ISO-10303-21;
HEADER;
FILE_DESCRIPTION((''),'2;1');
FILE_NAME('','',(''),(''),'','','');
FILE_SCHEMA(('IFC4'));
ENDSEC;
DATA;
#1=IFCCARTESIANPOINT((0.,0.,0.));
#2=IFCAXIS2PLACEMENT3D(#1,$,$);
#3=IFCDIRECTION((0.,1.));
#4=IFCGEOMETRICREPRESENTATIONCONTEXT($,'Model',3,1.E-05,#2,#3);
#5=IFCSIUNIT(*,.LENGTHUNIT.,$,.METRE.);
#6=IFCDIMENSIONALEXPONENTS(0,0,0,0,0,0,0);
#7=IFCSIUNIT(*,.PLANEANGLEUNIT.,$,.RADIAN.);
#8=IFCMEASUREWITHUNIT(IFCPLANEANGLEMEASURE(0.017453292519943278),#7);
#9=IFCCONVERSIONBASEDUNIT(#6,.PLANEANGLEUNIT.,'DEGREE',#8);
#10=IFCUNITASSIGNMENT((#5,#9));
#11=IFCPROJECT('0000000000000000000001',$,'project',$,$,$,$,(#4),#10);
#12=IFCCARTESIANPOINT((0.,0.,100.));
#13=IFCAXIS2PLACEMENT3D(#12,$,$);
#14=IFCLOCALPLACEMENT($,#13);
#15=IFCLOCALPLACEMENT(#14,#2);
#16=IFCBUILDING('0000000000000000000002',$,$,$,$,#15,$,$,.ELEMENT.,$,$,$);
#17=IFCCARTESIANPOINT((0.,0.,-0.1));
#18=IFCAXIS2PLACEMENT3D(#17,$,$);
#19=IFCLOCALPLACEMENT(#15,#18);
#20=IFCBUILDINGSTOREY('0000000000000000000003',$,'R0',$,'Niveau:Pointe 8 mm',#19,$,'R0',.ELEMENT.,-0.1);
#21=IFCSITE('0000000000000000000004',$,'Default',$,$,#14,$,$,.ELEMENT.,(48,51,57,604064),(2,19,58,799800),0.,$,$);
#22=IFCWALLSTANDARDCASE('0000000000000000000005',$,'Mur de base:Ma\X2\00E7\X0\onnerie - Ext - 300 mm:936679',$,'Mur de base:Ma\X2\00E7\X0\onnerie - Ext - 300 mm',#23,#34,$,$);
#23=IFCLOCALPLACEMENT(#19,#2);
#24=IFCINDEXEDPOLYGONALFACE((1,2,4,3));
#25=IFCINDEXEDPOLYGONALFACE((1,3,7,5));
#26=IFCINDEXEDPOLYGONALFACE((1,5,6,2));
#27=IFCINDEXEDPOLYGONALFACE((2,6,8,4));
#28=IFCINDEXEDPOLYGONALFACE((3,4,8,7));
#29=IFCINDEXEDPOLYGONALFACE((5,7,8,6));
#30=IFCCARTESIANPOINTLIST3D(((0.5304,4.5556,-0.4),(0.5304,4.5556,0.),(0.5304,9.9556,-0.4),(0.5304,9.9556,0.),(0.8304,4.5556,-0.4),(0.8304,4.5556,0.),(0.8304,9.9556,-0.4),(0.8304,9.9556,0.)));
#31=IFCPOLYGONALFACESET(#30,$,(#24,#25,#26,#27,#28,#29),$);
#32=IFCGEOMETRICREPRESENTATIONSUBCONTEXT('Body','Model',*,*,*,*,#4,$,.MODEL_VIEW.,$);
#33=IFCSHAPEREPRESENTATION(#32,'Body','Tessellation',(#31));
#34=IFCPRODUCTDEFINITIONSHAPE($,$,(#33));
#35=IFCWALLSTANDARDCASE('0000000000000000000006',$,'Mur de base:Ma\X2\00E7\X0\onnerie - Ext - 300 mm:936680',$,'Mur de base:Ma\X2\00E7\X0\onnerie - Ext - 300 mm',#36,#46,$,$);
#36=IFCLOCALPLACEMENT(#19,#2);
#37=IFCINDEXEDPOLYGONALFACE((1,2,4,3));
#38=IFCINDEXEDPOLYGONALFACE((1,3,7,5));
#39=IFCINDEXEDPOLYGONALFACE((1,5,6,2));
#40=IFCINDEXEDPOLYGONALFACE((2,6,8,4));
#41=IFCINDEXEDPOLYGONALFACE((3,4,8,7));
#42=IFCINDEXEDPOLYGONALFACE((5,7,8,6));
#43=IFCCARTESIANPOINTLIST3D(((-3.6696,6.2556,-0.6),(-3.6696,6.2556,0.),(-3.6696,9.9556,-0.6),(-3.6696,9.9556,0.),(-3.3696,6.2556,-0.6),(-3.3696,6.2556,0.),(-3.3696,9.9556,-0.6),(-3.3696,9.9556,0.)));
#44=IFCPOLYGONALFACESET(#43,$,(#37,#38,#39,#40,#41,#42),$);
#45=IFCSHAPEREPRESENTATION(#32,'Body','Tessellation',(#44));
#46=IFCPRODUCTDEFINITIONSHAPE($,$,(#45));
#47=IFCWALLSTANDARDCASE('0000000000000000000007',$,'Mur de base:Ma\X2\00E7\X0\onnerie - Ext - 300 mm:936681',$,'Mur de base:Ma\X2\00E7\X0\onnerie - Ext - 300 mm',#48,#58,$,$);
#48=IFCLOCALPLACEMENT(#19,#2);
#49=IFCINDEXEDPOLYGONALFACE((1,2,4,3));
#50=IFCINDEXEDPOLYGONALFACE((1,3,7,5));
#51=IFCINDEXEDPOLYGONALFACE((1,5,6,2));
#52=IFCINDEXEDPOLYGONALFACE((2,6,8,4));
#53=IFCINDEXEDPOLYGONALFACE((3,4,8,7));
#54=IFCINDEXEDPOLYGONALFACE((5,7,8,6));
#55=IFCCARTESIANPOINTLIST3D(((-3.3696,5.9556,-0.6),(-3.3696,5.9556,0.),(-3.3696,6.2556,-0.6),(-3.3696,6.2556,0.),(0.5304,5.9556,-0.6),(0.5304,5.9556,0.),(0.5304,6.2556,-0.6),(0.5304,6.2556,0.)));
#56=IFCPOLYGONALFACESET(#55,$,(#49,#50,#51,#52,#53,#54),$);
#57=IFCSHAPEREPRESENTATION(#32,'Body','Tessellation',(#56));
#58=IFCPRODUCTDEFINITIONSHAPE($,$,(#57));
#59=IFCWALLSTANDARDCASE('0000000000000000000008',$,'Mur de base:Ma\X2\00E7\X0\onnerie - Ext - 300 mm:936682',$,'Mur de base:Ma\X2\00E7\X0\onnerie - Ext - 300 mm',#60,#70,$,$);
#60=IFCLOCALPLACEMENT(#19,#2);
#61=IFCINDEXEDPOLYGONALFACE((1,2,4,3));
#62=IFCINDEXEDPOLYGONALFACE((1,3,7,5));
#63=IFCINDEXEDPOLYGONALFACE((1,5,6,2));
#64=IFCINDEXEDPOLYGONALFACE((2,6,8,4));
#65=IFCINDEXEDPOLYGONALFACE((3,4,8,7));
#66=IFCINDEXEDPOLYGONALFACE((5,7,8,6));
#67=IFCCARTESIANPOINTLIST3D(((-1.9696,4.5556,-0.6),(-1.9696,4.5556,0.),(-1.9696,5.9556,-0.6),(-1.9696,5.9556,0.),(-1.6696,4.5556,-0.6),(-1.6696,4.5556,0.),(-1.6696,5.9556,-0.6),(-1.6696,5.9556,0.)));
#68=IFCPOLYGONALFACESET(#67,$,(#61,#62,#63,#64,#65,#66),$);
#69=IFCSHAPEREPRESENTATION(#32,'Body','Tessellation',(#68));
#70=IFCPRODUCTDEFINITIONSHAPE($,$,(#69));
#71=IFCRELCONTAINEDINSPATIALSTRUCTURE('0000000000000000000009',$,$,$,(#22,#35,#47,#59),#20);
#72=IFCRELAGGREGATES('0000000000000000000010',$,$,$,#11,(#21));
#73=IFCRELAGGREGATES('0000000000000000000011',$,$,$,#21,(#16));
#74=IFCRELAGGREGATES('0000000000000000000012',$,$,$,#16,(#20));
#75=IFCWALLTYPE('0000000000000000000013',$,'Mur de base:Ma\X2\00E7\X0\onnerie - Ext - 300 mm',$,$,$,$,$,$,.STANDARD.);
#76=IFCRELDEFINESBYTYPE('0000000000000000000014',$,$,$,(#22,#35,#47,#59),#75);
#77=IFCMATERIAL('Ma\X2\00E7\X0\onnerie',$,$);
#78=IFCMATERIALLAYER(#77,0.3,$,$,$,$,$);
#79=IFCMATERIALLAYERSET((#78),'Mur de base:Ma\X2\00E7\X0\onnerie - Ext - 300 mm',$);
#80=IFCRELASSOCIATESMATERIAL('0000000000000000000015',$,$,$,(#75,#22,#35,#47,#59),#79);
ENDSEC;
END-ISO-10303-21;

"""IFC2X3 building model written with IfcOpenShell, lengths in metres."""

from ifc_helpers import new_model, entity, si_unit, converted_unit, direction, frame, frame_2d, origin, place, context, subcontext, project, spatial, polyline, rectangle, extrude, clip, bounded_halfspace, material, layer, layer_set, layer_usage, type_object, element, save


model = new_model("IFC2X3")

# Units and contexts
model_context = context("Model", 3, precision=1e-05, world=origin(), true_north=direction((0.0, 1.0)))
body_context = subcontext(model_context, "Body", "Model", "MODEL_VIEW")
ifc_project = project(units=[si_unit("LENGTHUNIT", "METRE"), converted_unit("PLANEANGLEUNIT", "DEGREE", entity("IfcPlaneAngleMeasure", 0.017453292519943278), si_unit("PLANEANGLEUNIT", "RADIAN"), dimensions=[0, 0, 0, 0, 0, 0, 0])], contexts=[model_context])

# Site, building, storey
site_placement = place(None, frame((0.0, 0.0, 100.0)))
site = spatial("IfcSite", under=ifc_project, at=site_placement, Name="Default", CompositionType="ELEMENT", RefLatitude=(48, 51, 57, 604064), RefLongitude=(2, 19, 58, 799800), RefElevation=0.0)
building_placement = place(site_placement, origin())
building = spatial("IfcBuilding", under=site, at=building_placement, CompositionType="ELEMENT")
storey_placement = place(building_placement, frame((0.0, 0.0, -0.1)))
storey = spatial("IfcBuildingStorey", under=building, at=storey_placement, Name="R0", ObjectType="Niveau:Pointe 8 mm", LongName="R0", CompositionType="ELEMENT", Elevation=-0.1)

# Shared definitions
ifc_material_1 = material(Name="Maçonnerie")

# Walls
ifc_layer_1 = layer(ifc_material_1, 0.3)
ifc_layer_set_1 = layer_set([ifc_layer_1], Name="Mur de base:Maçonnerie - Ext - 300 mm")
wall_type_1 = type_object("IfcWallType", Name="Mur de base:Maçonnerie - Ext - 300 mm", PredefinedType="STANDARD", material=ifc_layer_set_1)
ifc_layer_usage_1 = layer_usage(ifc_layer_set_1, "AXIS2", "NEGATIVE", 0.15)
wall_1_placement = place(storey_placement, frame((0.6804, 9.9556, -0.4), z_axis=(0.0, 0.0, 1.0), x_axis=(0.0, -1.0, 0.0)))
element("IfcWallStandardCase", 1, at=wall_1_placement, inside=storey, type_object=wall_type_1, material=ifc_layer_usage_1, Name="Mur de base:Maçonnerie - Ext - 300 mm:936679", ObjectType="Mur de base:Maçonnerie - Ext - 300 mm", context=body_context, shape_type="Clipping", body=[
    clip(extrude(rectangle(XDim=5.4, YDim=0.3, at=frame_2d((2.7, 0.0), x_axis=(-1.0, 0.0))), origin(), (0.0, 0.0, 1.0), 0.4), bounded_halfspace(frame((0.0, -0.15, 0.0), z_axis=(1.0, 0.0, 0.0), x_axis=(0.0, 0.0, -1.0)), True, frame((0.0, -0.15, 0.0), z_axis=(1.0, 0.0, 0.0), x_axis=(0.0, 0.0, -1.0)), polyline([(0.0, 0.0), (0.0, 0.3), (-0.4, 0.3), (-0.4, 0.05), (-0.4, 0.0), (0.0, 0.0)]))),
])
ifc_layer_usage_2 = layer_usage(ifc_layer_set_1, "AXIS2", "NEGATIVE", 0.15)
wall_2_placement = place(storey_placement, frame((-3.5196, 9.9556, -0.6), z_axis=(0.0, 0.0, 1.0), x_axis=(0.0, -1.0, 0.0)))
element("IfcWallStandardCase", 2, at=wall_2_placement, inside=storey, type_object=wall_type_1, material=ifc_layer_usage_2, Name="Mur de base:Maçonnerie - Ext - 300 mm:936680", ObjectType="Mur de base:Maçonnerie - Ext - 300 mm", context=body_context, shape_type="Clipping", body=[
    clip(extrude(rectangle(XDim=3.7, YDim=0.3, at=frame_2d((1.85, 0.0), x_axis=(-1.0, 0.0))), origin(), (0.0, 0.0, 1.0), 0.6), bounded_halfspace(frame((0.0, -0.15, 0.0), z_axis=(1.0, 0.0, 0.0), x_axis=(0.0, 0.0, -1.0)), True, frame((0.0, -0.15, 0.0), z_axis=(1.0, 0.0, 0.0), x_axis=(0.0, 0.0, -1.0)), polyline([(0.0, 0.0), (0.0, 0.3), (-0.6, 0.3), (-0.6, 0.25), (-0.6, 0.0), (0.0, 0.0)]))),
])
ifc_layer_usage_3 = layer_usage(ifc_layer_set_1, "AXIS2", "NEGATIVE", 0.15)
wall_3_placement = place(storey_placement, frame((-3.3696, 6.1056, -0.6)))
element("IfcWallStandardCase", 3, at=wall_3_placement, inside=storey, type_object=wall_type_1, material=ifc_layer_usage_3, Name="Mur de base:Maçonnerie - Ext - 300 mm:936681", ObjectType="Mur de base:Maçonnerie - Ext - 300 mm", context=body_context, shape_type="Clipping", body=[
    clip(extrude(rectangle(XDim=3.9, YDim=0.3, at=frame_2d((1.95, 0.0), x_axis=(-1.0, 0.0))), origin(), (0.0, 0.0, 1.0), 0.6), bounded_halfspace(frame((0.0, -0.15, 0.0), z_axis=(1.0, 0.0, 0.0), x_axis=(0.0, 0.0, -1.0)), True, frame((0.0, -0.15, 0.0), z_axis=(1.0, 0.0, 0.0), x_axis=(0.0, 0.0, -1.0)), polyline([(0.0, 0.0), (0.0, 0.3), (-0.6, 0.3), (-0.6, 0.25), (-0.6, 0.0), (0.0, 0.0)]))),
])
ifc_layer_usage_4 = layer_usage(ifc_layer_set_1, "AXIS2", "NEGATIVE", 0.15)
wall_4_placement = place(storey_placement, frame((-1.8196, 5.9556, -0.6), z_axis=(0.0, 0.0, 1.0), x_axis=(0.0, -1.0, 0.0)))
element("IfcWallStandardCase", 4, at=wall_4_placement, inside=storey, type_object=wall_type_1, material=ifc_layer_usage_4, Name="Mur de base:Maçonnerie - Ext - 300 mm:936682", ObjectType="Mur de base:Maçonnerie - Ext - 300 mm", context=body_context, shape_type="Clipping", body=[
    clip(extrude(rectangle(XDim=1.4, YDim=0.3, at=frame_2d((0.7, 0.0), x_axis=(-1.0, 0.0))), origin(), (0.0, 0.0, 1.0), 0.6), bounded_halfspace(frame((1.4, -0.15, 0.6), z_axis=(-1.0, 0.0, 0.0), x_axis=(0.0, 0.0, -1.0)), True, frame((1.4, -0.15, 0.6), z_axis=(-1.0, 0.0, 0.0), x_axis=(0.0, 0.0, -1.0)), polyline([(0.0, 0.0), (0.0, -0.25), (0.0, -0.3), (0.6, -0.3), (0.6, 0.0), (0.0, 0.0)]))),
])

save(model, "model.ifc")
